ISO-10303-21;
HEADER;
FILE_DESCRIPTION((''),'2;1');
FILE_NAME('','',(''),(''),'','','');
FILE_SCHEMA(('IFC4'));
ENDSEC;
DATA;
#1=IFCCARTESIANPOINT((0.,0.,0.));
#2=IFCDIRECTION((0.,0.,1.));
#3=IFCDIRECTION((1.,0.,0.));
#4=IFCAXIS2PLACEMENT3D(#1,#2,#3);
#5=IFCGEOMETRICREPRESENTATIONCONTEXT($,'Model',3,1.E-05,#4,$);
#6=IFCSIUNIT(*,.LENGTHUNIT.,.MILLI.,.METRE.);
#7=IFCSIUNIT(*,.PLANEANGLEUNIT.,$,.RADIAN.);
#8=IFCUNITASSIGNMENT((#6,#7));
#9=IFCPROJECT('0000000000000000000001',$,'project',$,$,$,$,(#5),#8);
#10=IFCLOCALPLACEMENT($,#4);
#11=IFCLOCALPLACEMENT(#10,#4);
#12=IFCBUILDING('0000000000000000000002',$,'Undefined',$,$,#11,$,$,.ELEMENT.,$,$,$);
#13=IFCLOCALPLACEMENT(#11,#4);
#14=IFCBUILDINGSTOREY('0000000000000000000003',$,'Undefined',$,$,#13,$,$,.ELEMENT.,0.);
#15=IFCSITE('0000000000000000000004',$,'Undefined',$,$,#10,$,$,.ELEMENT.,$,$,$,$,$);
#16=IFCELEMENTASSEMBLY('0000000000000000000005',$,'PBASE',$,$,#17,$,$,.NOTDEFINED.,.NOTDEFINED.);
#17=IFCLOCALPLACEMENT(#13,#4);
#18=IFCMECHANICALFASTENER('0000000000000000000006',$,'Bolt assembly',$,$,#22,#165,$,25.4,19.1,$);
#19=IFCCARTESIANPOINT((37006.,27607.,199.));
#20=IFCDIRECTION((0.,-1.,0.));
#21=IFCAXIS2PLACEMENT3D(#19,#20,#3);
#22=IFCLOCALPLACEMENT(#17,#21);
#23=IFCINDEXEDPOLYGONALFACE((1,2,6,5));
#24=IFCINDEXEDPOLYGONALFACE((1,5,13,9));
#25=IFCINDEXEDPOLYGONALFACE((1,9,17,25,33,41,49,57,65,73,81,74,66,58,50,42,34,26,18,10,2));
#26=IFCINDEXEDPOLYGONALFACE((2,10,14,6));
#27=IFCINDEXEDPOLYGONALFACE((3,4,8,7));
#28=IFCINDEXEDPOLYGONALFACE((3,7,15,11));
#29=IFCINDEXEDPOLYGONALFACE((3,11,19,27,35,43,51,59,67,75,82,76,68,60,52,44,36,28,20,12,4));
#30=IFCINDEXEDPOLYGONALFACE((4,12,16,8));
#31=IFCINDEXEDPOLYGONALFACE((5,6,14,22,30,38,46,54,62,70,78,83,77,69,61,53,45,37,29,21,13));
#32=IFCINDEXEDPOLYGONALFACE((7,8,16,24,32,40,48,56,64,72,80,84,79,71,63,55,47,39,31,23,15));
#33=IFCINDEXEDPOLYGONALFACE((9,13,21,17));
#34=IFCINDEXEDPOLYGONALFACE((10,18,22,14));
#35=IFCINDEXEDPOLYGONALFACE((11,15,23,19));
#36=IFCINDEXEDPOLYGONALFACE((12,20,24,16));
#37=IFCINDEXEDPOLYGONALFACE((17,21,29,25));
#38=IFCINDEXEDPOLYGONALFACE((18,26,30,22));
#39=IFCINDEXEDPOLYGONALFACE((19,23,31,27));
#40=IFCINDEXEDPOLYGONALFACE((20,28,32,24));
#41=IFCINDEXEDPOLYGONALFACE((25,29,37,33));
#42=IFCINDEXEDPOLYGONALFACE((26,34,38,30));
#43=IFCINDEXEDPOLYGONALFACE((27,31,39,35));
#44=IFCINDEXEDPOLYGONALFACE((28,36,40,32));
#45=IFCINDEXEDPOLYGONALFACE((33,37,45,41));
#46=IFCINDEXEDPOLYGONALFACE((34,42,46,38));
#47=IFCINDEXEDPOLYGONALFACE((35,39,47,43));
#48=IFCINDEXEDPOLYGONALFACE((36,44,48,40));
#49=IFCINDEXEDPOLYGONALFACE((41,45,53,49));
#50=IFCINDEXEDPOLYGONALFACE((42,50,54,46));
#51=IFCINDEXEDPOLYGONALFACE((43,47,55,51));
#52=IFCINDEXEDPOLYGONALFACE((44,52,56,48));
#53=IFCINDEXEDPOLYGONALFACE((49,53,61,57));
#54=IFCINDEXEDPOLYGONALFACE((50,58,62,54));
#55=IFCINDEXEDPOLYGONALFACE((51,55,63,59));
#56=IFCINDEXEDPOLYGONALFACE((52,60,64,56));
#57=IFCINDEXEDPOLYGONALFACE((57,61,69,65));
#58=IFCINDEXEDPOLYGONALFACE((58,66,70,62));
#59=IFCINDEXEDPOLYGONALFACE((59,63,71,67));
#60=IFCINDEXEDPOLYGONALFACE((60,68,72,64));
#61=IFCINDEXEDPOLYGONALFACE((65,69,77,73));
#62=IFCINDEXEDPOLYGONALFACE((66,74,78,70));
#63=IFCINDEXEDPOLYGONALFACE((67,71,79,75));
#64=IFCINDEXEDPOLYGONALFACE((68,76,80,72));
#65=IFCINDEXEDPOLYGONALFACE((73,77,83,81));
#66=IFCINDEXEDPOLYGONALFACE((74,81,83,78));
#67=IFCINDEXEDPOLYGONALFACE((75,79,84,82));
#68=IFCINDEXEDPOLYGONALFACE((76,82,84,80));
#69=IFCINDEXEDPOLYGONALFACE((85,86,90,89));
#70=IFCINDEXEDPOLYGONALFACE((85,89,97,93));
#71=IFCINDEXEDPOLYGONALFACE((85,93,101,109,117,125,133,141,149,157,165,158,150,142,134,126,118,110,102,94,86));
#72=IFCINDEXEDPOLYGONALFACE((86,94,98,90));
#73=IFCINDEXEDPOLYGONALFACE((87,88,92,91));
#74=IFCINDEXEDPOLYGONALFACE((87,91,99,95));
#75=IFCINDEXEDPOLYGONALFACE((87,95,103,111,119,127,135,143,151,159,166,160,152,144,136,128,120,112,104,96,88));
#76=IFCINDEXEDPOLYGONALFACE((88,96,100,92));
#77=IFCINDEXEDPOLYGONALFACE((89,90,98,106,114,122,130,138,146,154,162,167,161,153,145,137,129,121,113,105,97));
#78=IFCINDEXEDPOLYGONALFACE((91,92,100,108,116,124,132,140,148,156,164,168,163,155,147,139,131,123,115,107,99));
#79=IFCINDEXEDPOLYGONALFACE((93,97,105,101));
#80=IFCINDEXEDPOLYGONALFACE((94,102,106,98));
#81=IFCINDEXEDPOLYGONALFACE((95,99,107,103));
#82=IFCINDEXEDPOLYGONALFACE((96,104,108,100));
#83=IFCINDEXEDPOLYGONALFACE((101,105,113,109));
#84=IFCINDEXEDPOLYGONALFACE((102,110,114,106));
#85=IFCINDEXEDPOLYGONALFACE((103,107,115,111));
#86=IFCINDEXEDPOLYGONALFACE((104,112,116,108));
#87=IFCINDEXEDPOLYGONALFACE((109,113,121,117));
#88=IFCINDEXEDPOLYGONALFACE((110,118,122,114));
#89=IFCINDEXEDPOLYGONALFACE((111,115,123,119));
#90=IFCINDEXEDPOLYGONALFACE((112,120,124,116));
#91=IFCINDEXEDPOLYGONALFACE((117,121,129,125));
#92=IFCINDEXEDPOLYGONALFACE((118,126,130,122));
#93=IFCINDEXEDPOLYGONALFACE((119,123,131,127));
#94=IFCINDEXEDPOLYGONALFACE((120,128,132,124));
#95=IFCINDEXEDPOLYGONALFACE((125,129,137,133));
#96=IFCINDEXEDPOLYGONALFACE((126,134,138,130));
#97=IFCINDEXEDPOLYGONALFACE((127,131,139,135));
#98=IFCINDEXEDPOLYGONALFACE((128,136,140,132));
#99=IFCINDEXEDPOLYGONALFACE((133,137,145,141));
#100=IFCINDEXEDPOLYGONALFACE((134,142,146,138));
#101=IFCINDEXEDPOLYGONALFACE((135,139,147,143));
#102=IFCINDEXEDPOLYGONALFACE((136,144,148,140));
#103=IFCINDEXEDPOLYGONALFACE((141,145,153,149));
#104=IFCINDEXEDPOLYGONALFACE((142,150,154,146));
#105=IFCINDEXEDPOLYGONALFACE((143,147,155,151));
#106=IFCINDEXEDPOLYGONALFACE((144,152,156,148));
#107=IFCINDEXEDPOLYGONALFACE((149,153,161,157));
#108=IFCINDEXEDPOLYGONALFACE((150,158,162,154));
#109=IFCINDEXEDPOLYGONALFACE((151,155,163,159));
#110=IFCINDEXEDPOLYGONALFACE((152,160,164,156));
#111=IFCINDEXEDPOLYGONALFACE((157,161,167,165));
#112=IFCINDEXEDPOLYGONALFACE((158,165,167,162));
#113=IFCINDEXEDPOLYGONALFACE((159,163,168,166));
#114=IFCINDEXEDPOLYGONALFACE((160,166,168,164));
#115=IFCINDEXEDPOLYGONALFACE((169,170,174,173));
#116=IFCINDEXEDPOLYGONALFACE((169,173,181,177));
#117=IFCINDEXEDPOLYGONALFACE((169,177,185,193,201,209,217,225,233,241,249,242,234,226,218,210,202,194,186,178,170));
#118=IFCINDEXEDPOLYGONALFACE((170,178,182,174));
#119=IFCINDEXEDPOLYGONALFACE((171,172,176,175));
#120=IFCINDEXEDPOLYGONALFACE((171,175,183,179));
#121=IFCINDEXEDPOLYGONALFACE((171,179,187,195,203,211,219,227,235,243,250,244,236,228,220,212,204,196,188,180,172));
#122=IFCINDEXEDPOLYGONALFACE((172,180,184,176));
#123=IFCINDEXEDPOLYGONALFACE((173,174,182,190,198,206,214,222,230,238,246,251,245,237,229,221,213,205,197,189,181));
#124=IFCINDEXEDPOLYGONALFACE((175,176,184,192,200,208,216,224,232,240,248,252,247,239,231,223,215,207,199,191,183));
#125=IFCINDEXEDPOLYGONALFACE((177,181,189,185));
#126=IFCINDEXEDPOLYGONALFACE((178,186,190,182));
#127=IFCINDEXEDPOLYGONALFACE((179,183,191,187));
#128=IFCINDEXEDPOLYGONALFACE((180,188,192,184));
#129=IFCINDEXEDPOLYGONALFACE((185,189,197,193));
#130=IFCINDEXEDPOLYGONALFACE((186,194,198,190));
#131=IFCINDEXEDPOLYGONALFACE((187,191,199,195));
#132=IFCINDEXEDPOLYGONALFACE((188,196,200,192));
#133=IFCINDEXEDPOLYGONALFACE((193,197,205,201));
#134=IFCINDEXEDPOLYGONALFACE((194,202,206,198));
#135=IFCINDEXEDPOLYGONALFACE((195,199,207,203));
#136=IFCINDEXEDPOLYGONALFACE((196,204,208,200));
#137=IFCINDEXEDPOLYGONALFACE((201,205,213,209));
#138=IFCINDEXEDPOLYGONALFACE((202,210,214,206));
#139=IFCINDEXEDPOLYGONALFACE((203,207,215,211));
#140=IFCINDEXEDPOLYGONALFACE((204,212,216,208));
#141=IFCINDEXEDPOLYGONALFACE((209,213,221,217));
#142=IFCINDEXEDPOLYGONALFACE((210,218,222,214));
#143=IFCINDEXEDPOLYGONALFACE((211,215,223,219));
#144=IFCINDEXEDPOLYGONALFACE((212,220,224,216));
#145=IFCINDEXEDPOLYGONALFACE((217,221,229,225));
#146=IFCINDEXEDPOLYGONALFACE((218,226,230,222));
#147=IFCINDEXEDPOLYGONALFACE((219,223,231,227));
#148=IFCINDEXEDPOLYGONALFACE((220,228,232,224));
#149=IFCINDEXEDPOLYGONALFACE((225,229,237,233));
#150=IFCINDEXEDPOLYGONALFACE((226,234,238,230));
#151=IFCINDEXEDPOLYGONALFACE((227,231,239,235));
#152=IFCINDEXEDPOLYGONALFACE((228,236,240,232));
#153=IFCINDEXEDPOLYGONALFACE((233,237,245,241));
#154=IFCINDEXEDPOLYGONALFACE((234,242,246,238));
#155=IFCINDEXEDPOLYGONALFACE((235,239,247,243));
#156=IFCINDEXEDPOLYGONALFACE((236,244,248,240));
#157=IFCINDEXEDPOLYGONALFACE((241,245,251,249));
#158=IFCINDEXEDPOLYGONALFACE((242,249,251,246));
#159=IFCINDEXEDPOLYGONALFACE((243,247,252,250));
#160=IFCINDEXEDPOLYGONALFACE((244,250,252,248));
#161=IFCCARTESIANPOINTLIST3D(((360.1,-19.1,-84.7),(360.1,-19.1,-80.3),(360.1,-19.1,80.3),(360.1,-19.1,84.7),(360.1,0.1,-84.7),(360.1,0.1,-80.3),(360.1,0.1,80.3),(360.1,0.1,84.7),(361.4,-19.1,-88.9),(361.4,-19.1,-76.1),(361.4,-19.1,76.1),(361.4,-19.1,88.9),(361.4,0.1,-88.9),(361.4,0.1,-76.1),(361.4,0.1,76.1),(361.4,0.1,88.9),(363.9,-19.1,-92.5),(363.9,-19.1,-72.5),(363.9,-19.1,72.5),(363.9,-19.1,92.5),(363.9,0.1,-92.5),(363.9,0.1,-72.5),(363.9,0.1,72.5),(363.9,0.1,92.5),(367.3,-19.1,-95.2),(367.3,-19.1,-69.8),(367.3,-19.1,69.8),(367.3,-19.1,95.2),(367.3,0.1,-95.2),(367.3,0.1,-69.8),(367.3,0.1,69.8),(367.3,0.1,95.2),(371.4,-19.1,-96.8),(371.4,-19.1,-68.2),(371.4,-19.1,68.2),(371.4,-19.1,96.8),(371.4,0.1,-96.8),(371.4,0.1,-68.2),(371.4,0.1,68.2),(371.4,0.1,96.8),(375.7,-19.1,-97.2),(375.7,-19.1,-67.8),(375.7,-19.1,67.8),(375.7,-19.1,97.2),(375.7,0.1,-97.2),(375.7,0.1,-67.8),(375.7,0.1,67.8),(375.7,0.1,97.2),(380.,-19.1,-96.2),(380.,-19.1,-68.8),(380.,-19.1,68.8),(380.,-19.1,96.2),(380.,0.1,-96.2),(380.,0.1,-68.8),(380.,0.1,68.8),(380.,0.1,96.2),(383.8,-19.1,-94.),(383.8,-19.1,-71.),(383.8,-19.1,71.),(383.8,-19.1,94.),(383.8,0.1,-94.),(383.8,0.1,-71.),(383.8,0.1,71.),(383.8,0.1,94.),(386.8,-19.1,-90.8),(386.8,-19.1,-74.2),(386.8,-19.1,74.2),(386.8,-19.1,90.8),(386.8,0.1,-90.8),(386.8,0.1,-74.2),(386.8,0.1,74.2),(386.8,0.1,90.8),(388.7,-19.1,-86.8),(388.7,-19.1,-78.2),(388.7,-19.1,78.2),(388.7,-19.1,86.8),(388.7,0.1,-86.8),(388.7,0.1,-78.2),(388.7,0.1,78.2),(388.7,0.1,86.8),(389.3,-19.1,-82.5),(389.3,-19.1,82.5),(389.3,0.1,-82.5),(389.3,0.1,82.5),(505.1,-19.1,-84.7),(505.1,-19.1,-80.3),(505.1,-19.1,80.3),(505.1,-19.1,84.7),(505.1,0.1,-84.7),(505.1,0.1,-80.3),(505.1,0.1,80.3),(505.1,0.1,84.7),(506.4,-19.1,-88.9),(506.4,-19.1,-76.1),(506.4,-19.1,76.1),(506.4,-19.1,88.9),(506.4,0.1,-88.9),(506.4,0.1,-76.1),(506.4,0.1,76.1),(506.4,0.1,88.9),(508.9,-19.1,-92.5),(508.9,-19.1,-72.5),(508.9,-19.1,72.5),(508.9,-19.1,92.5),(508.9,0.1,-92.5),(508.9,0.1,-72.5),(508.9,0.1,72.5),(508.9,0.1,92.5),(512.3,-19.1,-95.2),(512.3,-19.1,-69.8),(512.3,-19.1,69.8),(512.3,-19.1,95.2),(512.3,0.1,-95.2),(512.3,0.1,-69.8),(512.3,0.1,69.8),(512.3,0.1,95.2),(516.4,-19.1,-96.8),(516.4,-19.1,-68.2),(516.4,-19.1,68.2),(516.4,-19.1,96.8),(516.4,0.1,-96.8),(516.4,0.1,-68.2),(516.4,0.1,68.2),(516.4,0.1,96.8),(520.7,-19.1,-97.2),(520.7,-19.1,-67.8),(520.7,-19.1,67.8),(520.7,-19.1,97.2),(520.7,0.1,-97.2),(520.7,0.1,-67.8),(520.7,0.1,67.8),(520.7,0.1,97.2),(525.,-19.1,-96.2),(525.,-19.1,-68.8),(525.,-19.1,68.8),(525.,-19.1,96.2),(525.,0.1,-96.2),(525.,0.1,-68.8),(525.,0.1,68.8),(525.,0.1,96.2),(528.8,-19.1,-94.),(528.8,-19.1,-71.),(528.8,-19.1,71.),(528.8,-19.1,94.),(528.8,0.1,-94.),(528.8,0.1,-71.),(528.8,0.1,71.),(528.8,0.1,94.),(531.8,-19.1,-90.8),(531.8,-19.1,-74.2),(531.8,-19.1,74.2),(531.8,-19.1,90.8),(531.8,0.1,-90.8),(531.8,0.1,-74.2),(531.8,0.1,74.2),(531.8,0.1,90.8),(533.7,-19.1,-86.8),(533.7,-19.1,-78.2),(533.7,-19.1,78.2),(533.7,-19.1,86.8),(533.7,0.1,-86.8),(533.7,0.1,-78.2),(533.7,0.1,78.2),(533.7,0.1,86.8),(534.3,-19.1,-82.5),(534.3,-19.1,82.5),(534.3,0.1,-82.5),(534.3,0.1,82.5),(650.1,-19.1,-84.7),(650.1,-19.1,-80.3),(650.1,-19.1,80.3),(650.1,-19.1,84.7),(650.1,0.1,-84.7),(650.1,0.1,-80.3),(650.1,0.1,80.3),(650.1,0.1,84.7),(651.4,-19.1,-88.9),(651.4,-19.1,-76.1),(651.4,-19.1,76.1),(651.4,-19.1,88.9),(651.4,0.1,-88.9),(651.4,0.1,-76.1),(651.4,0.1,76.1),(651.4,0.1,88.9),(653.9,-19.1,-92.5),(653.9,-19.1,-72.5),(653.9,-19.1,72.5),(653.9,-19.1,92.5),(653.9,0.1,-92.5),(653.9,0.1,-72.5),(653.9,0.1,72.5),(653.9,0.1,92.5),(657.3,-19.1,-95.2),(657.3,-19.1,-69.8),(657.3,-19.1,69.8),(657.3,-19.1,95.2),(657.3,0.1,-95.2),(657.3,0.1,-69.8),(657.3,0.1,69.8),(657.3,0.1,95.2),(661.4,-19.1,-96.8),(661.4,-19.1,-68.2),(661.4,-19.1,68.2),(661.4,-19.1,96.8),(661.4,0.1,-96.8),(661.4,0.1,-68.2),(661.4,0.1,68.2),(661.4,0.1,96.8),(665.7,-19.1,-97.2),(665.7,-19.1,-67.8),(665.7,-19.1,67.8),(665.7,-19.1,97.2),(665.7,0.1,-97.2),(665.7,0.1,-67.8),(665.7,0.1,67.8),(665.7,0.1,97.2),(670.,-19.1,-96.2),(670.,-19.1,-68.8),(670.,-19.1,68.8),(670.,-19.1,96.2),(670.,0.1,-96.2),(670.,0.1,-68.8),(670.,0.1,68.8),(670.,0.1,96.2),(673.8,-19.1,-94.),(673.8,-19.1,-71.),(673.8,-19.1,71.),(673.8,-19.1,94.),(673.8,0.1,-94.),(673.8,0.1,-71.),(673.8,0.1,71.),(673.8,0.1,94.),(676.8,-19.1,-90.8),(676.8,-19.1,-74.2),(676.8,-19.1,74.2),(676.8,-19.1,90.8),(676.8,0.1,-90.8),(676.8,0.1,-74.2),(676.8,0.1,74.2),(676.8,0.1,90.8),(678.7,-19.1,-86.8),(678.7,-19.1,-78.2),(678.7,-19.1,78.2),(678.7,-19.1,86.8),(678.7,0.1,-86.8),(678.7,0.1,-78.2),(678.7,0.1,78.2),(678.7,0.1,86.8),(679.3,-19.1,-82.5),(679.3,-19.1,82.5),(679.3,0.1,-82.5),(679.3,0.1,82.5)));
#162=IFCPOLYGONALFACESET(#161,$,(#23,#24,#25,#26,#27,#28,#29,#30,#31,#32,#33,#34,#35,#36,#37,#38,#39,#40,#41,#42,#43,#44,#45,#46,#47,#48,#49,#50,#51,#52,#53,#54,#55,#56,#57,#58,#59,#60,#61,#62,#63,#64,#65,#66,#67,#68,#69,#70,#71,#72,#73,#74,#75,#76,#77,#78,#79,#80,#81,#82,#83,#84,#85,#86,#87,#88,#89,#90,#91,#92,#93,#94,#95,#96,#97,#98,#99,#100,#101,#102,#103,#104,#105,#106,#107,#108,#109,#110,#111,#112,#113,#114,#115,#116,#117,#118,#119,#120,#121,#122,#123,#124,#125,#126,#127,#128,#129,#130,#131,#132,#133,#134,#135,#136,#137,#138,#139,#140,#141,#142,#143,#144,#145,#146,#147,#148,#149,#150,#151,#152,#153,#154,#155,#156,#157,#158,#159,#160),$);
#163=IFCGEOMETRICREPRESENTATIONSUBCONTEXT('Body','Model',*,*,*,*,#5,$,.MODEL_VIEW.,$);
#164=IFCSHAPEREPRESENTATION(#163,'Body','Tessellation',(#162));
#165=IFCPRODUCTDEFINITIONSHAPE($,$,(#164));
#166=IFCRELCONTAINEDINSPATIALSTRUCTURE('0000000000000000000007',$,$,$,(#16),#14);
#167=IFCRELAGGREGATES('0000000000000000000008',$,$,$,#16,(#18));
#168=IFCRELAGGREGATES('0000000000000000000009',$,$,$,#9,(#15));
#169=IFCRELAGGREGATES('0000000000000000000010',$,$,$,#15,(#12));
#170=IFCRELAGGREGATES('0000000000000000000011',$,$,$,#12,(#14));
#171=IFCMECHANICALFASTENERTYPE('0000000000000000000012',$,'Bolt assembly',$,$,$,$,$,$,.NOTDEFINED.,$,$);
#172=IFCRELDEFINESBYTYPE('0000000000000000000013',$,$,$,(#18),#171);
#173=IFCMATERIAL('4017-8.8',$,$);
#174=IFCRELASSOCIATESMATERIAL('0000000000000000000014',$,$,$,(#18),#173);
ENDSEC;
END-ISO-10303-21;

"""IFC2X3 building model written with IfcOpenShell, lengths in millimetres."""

from ifc_helpers import new_model, si_unit, frame, origin_with_axes, origin_2d_with_axis, place, context, subcontext, project, spatial, circle, extrude, source, transform, mapped, material, type_object, element, aggregate, save


model = new_model("IFC2X3")

# Units and contexts
model_context = context("Model", 3, precision=1e-05, world=origin_with_axes())
body_context = subcontext(model_context, "Body", "Model", "MODEL_VIEW")
ifc_project = project(units=[si_unit("LENGTHUNIT", "METRE", prefix="MILLI"), si_unit("PLANEANGLEUNIT", "RADIAN")], contexts=[model_context])

# Site, building, storey
site_placement = place(None, origin_with_axes())
site = spatial("IfcSite", under=ifc_project, at=site_placement, Name="Undefined", CompositionType="ELEMENT")
building_placement = place(site_placement, origin_with_axes())
building = spatial("IfcBuilding", under=site, at=building_placement, Name="Undefined", CompositionType="ELEMENT")
storey_placement = place(building_placement, origin_with_axes())
storey = spatial("IfcBuildingStorey", under=building, at=storey_placement, Name="Undefined", CompositionType="ELEMENT", Elevation=0.0)

# Element assembly
assembly_1_placement = place(storey_placement, origin_with_axes())
assembly_1 = element("IfcElementAssembly", 1, at=assembly_1_placement, inside=storey, Name="PBASE", AssemblyPlace="NOTDEFINED", PredefinedType="NOTDEFINED")

# Mechanical fastener
mechanical_fastener_type = type_object("IfcMechanicalFastenerType", Name="Bolt assembly")
ifc_material_1 = material(Name="4017-8.8")
shared_shape_1 = source(origin_with_axes(), body_context, "Body", "SweptSolid", [
    extrude(circle(Radius=14.7, at=origin_2d_with_axis()), frame((0.0, -19.1, 0.0), z_axis=(0.0, 1.0, 0.0), x_axis=(1.0, 0.0, 0.0)), (0.0, 0.0, 1.0), 19.2),
])
mechanical_fastener_1_placement = place(assembly_1_placement, frame((37006.0, 27607.0, 199.0), z_axis=(0.0, -1.0, 0.0), x_axis=(1.0, 0.0, 0.0)))
mechanical_fastener_1 = element("IfcMechanicalFastener", 2, at=mechanical_fastener_1_placement, type_object=mechanical_fastener_type, material=ifc_material_1, Name="Bolt assembly", NominalDiameter=25.4, NominalLength=19.1, context=body_context, shape_type="MappedRepresentation", body=[
    mapped(shared_shape_1, transform((374.6, 0.0, -82.5))),
    mapped(shared_shape_1, transform((374.6, 0.0, 82.5))),
    mapped(shared_shape_1, transform((519.6, 0.0, -82.5))),
    mapped(shared_shape_1, transform((519.6, 0.0, 82.5))),
    mapped(shared_shape_1, transform((664.6, 0.0, -82.5))),
    mapped(shared_shape_1, transform((664.6, 0.0, 82.5))),
])
aggregate(assembly_1, [mechanical_fastener_1])

save(model, "model.ifc")
